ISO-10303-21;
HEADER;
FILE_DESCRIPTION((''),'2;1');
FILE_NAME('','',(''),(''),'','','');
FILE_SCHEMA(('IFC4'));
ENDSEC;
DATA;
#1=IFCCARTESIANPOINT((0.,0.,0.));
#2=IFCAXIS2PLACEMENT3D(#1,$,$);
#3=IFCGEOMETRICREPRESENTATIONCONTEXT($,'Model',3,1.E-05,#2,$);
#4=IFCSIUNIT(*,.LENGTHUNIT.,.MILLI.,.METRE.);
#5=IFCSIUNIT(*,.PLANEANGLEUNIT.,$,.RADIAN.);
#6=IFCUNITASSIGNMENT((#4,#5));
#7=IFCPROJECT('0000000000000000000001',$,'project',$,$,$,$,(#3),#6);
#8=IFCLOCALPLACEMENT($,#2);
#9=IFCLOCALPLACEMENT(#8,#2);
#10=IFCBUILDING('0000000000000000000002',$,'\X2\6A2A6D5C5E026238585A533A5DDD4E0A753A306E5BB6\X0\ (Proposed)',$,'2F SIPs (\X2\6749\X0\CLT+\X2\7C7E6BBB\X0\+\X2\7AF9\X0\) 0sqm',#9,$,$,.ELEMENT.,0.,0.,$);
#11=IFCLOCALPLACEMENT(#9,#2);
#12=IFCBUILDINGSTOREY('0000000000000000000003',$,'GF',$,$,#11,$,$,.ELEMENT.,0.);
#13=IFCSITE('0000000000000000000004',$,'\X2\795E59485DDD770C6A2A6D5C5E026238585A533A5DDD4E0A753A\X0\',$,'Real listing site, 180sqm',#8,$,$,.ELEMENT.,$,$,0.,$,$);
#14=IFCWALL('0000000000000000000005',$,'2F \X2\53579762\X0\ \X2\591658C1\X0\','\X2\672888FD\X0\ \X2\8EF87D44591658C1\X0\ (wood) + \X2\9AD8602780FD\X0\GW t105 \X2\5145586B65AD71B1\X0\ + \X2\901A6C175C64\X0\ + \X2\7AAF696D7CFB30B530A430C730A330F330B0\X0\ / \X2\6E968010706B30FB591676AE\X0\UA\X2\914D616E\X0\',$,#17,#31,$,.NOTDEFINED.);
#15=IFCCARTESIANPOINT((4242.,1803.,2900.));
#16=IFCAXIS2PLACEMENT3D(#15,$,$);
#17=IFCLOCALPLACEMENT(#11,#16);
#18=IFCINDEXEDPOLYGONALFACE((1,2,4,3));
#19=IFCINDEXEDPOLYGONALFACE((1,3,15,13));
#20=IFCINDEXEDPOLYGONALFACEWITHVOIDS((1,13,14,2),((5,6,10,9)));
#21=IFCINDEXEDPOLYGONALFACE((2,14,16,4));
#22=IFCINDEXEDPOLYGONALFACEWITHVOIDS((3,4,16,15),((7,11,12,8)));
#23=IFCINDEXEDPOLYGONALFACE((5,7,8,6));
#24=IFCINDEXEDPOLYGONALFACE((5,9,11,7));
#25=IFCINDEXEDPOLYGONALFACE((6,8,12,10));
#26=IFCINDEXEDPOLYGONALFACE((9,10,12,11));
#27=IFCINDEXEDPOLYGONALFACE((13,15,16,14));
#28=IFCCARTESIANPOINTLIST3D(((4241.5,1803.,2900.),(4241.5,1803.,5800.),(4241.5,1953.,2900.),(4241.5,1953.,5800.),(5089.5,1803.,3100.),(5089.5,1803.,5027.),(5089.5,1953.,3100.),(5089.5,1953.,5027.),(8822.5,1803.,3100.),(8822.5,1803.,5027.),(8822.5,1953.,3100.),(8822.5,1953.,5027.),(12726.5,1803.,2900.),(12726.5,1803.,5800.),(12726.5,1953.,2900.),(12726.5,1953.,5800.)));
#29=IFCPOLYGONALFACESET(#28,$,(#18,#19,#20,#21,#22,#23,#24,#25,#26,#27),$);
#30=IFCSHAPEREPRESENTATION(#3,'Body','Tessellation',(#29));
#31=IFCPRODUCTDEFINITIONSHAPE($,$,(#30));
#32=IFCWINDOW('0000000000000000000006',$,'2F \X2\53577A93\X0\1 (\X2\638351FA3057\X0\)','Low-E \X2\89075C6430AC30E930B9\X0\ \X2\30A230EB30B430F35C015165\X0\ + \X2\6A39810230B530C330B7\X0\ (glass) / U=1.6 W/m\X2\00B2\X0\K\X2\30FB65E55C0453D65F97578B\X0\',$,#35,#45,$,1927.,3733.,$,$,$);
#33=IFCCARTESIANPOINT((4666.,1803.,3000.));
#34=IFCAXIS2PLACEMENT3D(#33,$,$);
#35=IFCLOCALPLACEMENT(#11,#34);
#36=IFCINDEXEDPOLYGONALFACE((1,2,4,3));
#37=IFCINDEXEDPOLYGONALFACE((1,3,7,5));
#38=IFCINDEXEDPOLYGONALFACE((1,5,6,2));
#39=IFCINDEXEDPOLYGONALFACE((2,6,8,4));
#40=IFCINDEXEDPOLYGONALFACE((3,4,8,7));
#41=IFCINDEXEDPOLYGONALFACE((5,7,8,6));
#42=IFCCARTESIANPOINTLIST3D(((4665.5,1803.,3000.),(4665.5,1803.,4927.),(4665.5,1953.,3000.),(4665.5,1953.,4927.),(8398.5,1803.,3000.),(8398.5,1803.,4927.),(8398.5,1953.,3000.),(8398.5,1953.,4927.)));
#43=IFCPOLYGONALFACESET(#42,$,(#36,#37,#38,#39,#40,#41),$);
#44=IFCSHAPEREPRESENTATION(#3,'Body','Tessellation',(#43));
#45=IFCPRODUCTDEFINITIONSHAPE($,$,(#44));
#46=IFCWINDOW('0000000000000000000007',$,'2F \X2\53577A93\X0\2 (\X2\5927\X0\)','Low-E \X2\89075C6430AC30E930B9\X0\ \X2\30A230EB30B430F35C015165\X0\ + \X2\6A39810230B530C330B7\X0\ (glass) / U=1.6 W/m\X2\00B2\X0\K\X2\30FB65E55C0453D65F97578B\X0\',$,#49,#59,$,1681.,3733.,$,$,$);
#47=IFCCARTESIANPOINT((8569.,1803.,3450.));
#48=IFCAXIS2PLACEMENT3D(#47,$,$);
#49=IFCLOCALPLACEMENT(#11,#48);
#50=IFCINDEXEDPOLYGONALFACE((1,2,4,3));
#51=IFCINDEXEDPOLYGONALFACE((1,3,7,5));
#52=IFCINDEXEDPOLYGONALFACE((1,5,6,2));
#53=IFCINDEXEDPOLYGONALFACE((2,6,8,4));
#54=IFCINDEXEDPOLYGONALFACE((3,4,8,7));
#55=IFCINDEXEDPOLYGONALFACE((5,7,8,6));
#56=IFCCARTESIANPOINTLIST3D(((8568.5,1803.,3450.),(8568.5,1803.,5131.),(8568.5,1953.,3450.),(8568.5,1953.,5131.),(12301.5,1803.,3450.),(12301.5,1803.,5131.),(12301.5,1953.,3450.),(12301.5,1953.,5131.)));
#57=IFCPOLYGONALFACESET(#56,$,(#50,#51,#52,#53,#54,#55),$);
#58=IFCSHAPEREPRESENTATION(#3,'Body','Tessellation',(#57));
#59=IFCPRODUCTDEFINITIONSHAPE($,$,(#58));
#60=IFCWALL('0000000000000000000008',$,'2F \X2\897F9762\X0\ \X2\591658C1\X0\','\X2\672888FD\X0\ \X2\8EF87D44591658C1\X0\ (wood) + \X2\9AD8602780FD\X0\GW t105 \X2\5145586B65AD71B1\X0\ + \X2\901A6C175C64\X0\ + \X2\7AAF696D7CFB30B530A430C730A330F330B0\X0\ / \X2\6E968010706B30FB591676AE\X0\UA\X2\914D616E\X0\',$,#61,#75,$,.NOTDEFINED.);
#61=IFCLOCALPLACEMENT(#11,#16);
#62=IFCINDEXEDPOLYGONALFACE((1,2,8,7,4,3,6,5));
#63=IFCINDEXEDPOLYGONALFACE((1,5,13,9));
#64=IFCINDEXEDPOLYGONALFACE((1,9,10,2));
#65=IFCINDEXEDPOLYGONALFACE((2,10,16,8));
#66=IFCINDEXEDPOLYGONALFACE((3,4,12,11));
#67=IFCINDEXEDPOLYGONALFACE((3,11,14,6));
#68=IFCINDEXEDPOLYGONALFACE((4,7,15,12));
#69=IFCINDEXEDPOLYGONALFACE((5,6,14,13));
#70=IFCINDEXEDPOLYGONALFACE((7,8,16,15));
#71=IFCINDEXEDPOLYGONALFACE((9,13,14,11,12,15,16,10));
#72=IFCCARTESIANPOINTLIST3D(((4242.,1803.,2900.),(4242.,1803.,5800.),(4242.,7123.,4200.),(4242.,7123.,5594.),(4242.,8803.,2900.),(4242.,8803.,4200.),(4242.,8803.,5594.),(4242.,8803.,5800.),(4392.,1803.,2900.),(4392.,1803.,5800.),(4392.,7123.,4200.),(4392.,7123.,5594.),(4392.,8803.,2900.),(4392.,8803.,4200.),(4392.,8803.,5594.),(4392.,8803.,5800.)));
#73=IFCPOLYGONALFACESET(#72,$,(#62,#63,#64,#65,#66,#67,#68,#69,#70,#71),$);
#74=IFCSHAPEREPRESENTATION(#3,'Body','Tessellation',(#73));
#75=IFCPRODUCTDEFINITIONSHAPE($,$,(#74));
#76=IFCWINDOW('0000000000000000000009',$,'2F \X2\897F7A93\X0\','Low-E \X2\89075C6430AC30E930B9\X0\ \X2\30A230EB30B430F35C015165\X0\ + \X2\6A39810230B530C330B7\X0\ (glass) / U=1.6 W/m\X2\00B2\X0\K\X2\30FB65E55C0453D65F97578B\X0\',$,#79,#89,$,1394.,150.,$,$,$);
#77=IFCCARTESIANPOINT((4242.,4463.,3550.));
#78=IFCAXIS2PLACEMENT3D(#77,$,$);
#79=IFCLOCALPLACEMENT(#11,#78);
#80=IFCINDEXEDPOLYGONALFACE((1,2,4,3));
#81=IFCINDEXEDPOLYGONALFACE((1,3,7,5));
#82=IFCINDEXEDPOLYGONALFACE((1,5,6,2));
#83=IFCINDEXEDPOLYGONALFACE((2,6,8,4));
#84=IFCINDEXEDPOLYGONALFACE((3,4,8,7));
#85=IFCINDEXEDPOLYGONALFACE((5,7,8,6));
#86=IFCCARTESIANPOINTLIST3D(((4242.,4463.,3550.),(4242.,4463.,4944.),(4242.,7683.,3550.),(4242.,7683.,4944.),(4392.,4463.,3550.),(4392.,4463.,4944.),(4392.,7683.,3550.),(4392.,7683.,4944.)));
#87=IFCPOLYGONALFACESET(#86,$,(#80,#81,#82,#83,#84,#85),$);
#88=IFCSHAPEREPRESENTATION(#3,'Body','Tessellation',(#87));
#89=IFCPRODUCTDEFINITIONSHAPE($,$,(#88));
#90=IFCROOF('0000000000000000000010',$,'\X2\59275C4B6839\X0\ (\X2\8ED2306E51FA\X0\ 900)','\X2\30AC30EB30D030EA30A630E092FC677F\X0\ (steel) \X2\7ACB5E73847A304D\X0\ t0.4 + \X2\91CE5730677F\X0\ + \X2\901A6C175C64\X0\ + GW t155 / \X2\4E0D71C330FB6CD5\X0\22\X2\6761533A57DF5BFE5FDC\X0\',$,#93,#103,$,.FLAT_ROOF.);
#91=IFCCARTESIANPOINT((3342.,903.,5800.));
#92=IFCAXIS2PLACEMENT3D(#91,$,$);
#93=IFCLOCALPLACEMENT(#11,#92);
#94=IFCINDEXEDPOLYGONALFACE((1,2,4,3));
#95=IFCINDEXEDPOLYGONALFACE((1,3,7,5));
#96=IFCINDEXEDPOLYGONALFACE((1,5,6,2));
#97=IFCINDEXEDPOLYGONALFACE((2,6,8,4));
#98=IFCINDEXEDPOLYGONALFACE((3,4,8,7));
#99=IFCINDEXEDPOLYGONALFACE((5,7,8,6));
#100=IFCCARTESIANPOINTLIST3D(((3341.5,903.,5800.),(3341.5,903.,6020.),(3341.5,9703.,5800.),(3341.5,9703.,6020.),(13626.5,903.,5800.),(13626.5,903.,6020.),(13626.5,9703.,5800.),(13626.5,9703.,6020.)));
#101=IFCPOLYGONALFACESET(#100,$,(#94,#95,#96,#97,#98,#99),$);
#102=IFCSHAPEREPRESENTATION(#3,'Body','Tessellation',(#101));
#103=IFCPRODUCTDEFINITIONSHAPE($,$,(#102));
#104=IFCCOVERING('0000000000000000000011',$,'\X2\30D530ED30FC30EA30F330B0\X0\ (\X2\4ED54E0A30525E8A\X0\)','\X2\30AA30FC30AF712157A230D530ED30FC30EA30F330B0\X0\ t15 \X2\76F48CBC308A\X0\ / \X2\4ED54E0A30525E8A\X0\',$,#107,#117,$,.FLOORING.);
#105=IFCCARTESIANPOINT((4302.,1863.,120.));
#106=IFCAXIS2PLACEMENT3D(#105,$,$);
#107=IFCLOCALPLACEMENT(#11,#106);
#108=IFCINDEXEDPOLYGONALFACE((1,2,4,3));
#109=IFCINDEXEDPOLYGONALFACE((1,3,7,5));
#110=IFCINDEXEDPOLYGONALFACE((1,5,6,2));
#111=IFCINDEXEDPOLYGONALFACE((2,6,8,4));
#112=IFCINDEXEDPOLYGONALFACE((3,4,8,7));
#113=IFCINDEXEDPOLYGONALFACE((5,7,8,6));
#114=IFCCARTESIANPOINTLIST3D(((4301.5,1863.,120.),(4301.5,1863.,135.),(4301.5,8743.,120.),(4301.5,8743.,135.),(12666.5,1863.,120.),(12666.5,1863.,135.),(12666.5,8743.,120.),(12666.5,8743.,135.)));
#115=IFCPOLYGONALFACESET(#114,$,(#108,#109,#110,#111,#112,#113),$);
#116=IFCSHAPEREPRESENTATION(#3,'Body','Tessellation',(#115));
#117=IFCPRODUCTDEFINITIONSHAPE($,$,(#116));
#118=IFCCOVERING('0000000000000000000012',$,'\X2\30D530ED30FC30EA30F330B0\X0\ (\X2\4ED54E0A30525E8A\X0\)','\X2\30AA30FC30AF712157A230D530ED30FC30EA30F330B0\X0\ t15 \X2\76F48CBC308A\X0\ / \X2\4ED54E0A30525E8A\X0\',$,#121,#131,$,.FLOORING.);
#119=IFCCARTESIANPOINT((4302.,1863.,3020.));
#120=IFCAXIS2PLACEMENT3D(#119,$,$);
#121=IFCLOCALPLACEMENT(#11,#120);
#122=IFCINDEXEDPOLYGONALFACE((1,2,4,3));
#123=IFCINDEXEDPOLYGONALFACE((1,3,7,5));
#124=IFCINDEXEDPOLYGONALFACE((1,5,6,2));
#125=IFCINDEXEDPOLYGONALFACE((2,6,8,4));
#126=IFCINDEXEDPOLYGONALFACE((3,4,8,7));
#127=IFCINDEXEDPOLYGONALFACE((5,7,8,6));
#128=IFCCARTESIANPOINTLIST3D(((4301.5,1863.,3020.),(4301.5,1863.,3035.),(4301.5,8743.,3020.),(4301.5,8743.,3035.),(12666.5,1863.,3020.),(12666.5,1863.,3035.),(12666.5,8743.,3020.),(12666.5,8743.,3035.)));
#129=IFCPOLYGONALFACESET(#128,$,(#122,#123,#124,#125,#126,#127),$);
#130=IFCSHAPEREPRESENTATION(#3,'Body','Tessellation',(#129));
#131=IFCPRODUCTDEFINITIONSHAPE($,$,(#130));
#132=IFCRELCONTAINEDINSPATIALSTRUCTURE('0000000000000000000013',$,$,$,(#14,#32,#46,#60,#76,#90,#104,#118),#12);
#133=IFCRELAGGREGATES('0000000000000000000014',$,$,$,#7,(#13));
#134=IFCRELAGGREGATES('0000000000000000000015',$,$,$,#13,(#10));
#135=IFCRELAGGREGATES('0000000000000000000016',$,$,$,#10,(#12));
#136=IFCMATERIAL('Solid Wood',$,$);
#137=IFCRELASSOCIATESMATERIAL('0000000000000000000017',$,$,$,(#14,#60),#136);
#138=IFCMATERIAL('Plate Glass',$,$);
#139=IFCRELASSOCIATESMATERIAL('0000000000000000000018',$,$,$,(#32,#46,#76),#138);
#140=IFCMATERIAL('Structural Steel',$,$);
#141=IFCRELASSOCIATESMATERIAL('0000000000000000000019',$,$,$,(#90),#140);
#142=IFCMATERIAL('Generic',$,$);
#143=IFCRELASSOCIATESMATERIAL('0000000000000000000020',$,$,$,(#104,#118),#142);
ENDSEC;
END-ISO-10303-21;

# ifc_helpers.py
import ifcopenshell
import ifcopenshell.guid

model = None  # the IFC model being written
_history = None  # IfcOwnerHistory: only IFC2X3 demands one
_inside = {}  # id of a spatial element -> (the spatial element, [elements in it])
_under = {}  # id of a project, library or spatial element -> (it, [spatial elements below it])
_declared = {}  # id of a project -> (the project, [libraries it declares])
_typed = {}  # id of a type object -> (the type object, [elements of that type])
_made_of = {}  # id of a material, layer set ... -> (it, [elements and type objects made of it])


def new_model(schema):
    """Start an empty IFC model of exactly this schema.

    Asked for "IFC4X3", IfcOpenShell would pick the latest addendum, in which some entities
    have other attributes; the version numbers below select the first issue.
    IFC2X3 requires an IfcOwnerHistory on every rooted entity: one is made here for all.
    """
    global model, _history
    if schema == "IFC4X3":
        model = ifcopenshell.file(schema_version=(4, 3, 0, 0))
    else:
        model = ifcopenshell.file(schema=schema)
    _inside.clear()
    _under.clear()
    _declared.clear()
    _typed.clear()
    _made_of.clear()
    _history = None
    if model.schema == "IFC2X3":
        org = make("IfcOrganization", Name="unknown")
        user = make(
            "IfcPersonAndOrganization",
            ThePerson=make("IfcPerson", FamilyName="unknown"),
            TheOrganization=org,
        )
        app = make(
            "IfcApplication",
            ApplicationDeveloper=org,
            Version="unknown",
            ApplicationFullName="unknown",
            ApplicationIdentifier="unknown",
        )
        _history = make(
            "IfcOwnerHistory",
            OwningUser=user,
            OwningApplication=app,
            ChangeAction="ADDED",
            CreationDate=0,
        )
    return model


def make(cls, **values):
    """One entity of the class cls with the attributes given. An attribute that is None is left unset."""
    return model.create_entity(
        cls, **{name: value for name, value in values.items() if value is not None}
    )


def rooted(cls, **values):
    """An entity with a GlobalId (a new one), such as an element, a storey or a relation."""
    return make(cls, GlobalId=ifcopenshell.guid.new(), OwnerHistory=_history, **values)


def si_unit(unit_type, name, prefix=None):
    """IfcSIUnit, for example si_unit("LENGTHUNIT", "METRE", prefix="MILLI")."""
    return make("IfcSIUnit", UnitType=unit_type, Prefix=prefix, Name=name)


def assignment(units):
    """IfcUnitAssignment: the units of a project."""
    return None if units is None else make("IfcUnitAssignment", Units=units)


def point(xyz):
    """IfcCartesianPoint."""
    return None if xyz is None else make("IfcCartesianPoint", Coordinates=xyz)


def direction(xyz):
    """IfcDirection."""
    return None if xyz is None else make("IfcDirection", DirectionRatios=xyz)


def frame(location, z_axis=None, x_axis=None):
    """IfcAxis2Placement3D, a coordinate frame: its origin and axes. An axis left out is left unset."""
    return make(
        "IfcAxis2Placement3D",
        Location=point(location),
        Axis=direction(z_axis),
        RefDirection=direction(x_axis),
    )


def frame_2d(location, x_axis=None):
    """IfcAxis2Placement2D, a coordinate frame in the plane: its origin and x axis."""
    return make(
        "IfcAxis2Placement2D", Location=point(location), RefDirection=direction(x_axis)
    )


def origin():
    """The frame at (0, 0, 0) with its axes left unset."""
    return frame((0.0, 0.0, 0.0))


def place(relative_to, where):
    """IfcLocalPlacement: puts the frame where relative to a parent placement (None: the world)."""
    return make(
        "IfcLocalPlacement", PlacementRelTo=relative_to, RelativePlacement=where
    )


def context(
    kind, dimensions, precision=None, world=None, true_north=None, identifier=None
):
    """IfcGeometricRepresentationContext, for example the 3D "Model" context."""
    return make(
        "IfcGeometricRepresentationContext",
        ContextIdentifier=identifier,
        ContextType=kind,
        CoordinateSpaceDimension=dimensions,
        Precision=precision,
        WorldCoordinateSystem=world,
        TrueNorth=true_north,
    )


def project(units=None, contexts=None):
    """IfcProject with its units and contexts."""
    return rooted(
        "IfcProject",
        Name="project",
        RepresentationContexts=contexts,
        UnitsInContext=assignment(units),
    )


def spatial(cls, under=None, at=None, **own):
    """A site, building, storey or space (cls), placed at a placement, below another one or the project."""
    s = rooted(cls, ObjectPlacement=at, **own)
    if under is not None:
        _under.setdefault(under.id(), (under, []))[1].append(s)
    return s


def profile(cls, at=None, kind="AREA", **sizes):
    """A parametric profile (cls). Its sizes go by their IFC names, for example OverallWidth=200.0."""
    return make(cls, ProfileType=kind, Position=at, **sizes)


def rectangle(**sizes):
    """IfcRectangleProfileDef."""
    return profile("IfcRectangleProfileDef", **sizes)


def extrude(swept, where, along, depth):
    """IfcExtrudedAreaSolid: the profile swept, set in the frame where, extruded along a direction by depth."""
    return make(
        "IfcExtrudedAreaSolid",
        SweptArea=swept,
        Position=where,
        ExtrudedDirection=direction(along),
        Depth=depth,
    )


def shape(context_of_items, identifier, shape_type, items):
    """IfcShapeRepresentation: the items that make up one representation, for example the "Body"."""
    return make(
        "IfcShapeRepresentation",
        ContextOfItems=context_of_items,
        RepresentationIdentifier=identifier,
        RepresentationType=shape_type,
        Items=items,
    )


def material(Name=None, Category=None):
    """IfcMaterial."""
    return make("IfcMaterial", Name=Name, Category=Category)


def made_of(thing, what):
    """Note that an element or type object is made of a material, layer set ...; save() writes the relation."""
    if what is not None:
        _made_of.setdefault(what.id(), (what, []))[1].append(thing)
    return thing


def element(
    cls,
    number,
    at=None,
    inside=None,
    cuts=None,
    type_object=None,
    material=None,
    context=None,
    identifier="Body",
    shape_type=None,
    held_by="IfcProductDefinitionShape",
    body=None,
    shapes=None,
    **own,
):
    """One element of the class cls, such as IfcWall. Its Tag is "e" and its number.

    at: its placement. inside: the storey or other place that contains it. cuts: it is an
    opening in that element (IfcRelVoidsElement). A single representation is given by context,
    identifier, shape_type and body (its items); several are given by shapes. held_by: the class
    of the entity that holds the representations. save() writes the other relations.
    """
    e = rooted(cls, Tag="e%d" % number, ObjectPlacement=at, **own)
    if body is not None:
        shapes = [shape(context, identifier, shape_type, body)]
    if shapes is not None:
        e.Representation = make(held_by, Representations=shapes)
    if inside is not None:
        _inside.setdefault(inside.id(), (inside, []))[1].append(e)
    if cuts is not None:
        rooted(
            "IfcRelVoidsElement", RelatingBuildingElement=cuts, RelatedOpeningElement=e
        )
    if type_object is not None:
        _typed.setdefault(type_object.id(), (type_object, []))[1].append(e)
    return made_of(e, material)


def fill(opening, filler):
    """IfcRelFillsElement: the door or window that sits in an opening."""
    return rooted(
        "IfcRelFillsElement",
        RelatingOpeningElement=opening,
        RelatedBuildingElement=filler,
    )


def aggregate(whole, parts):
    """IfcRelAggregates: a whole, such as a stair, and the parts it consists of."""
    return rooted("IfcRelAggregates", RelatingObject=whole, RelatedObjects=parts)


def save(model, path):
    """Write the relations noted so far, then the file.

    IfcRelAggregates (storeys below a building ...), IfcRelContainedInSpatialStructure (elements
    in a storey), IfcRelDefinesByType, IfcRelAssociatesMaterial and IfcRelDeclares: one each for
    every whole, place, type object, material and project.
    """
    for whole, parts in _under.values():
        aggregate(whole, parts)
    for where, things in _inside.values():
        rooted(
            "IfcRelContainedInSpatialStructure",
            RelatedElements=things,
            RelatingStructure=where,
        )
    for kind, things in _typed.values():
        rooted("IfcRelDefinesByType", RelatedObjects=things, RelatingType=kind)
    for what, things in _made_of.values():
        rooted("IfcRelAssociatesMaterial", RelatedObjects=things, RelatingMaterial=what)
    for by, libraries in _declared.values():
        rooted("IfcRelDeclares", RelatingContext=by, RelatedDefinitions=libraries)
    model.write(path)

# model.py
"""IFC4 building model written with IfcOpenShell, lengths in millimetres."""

from ifc_helpers import new_model, si_unit, frame, frame_2d, origin, place, context, project, spatial, rectangle, extrude, material, element, fill, save


model = new_model("IFC4")

# Units and contexts
model_context = context("Model", 3, precision=1e-05, world=origin())
ifc_project = project(units=[si_unit("LENGTHUNIT", "METRE", prefix="MILLI"), si_unit("PLANEANGLEUNIT", "RADIAN")], contexts=[model_context])

# Site, building, storey
site_placement = place(None, origin())
site = spatial("IfcSite", under=ifc_project, at=site_placement, Name="神奈川県横浜市戸塚区川上町", ObjectType="Real listing site, 180sqm", CompositionType="ELEMENT", RefElevation=0.0)
building_placement = place(site_placement, origin())
building = spatial("IfcBuilding", under=site, at=building_placement, Name="横浜市戸塚区川上町の家 (Proposed)", ObjectType="2F SIPs (杉CLT+籾殻+竹) 0sqm", CompositionType="ELEMENT", ElevationOfRefHeight=0.0, ElevationOfTerrain=0.0)
storey_placement = place(building_placement, origin())
storey = spatial("IfcBuildingStorey", under=building, at=storey_placement, Name="GF", CompositionType="ELEMENT", Elevation=0.0)

# Shared definitions
ifc_material_1 = material(Name="Solid Wood")

# Shared definitions
ifc_material_2 = material(Name="Plate Glass")

# Wall, openings, windows
wall_1_placement = place(storey_placement, frame((4242.0, 1803.0, 2900.0)))
wall_1 = element("IfcWall", 1, at=wall_1_placement, inside=storey, material=ifc_material_1, Name="2F 南面 外壁", Description="木製 軸組外壁 (wood) + 高性能GW t105 充填断熱 + 通気層 + 窯業系サイディング / 準耐火・外皮UA配慮", PredefinedType="NOTDEFINED", context=model_context, shape_type="SweptSolid", body=[
    extrude(rectangle(XDim=8485.0, YDim=150.0, at=frame_2d((4242.0, 75.0))), frame((4242.0, 1803.0, 2900.0)), (0.0, 0.0, 1.0), 2900.0),
])
opening_1_placement = place(storey_placement, frame((4666.0, 1803.0, 3000.0)))
opening_1 = element("IfcOpeningElement", 2, at=opening_1_placement, cuts=wall_1, PredefinedType="NOTDEFINED", context=model_context, shape_type="SweptSolid", body=[
    extrude(rectangle(XDim=3733.0, YDim=150.0, at=frame_2d((1866.0, 75.0))), frame((4666.0, 1803.0, 3000.0)), (0.0, 0.0, 1.0), 1927.0),
])
opening_2_placement = place(storey_placement, frame((8569.0, 1803.0, 3450.0)))
opening_2 = element("IfcOpeningElement", 3, at=opening_2_placement, cuts=wall_1, PredefinedType="NOTDEFINED", context=model_context, shape_type="SweptSolid", body=[
    extrude(rectangle(XDim=3733.0, YDim=150.0, at=frame_2d((1866.0, 75.0))), frame((8569.0, 1803.0, 3450.0)), (0.0, 0.0, 1.0), 1681.0),
])
window_1_placement = place(storey_placement, frame((4666.0, 1803.0, 3000.0)))
window_1 = element("IfcWindow", 4, at=window_1_placement, inside=storey, material=ifc_material_2, Name="2F 南窓1 (掃出し)", Description="Low-E 複層ガラス アルゴン封入 + 樹脂サッシ (glass) / U=1.6 W/m²K・日射取得型", OverallHeight=1927.0, OverallWidth=3733.0, context=model_context, shape_type="SweptSolid", body=[
    extrude(rectangle(XDim=3733.0, YDim=150.0, at=frame_2d((1866.0, 75.0))), frame((4666.0, 1803.0, 3000.0)), (0.0, 0.0, 1.0), 1927.0),
])
fill(opening_1, window_1)
window_2_placement = place(storey_placement, frame((8569.0, 1803.0, 3450.0)))
window_2 = element("IfcWindow", 5, at=window_2_placement, inside=storey, material=ifc_material_2, Name="2F 南窓2 (大)", Description="Low-E 複層ガラス アルゴン封入 + 樹脂サッシ (glass) / U=1.6 W/m²K・日射取得型", OverallHeight=1681.0, OverallWidth=3733.0, context=model_context, shape_type="SweptSolid", body=[
    extrude(rectangle(XDim=3733.0, YDim=150.0, at=frame_2d((1866.0, 75.0))), frame((8569.0, 1803.0, 3450.0)), (0.0, 0.0, 1.0), 1681.0),
])
fill(opening_2, window_2)

# Wall, opening, window
wall_2_placement = place(storey_placement, frame((4242.0, 1803.0, 2900.0)))
wall_2 = element("IfcWall", 6, at=wall_2_placement, inside=storey, material=ifc_material_1, Name="2F 西面 外壁", Description="木製 軸組外壁 (wood) + 高性能GW t105 充填断熱 + 通気層 + 窯業系サイディング / 準耐火・外皮UA配慮", PredefinedType="NOTDEFINED", context=model_context, shape_type="SweptSolid", body=[
    extrude(rectangle(XDim=150.0, YDim=7000.0, at=frame_2d((75.0, 3500.0))), frame((4242.0, 1803.0, 2900.0)), (0.0, 0.0, 1.0), 2900.0),
])
opening_3_placement = place(storey_placement, frame((4242.0, 4463.0, 3550.0)))
opening_3 = element("IfcOpeningElement", 7, at=opening_3_placement, cuts=wall_2, PredefinedType="NOTDEFINED", context=model_context, shape_type="SweptSolid", body=[
    extrude(rectangle(XDim=150.0, YDim=3220.0, at=frame_2d((75.0, 1610.0))), frame((4242.0, 4463.0, 3550.0)), (0.0, 0.0, 1.0), 1394.0),
])
window_3_placement = place(storey_placement, frame((4242.0, 4463.0, 3550.0)))
window_3 = element("IfcWindow", 8, at=window_3_placement, inside=storey, material=ifc_material_2, Name="2F 西窓", Description="Low-E 複層ガラス アルゴン封入 + 樹脂サッシ (glass) / U=1.6 W/m²K・日射取得型", OverallHeight=1394.0, OverallWidth=150.0, context=model_context, shape_type="SweptSolid", body=[
    extrude(rectangle(XDim=150.0, YDim=3220.0, at=frame_2d((75.0, 1610.0))), frame((4242.0, 4463.0, 3550.0)), (0.0, 0.0, 1.0), 1394.0),
])
fill(opening_3, window_3)

# Roof
ifc_material_3 = material(Name="Structural Steel")
roof_placement = place(storey_placement, frame((3342.0, 903.0, 5800.0)))
element("IfcRoof", 9, at=roof_placement, inside=storey, material=ifc_material_3, Name="大屋根 (軒の出 900)", Description="ガルバリウム鋼板 (steel) 立平葺き t0.4 + 野地板 + 通気層 + GW t155 / 不燃・法22条区域対応", PredefinedType="FLAT_ROOF", context=model_context, shape_type="SweptSolid", body=[
    extrude(rectangle(XDim=10285.0, YDim=8800.0, at=frame_2d((5142.0, 4400.0))), frame((3342.0, 903.0, 5800.0)), (0.0, 0.0, 1.0), 220.0),
])

# Coverings
ifc_material_4 = material(Name="Generic")
covering_1_placement = place(storey_placement, frame((4302.0, 1863.0, 120.0)))
element("IfcCovering", 10, at=covering_1_placement, inside=storey, material=ifc_material_4, Name="フローリング (仕上げ床)", Description="オーク無垢フローリング t15 直貼り / 仕上げ床", PredefinedType="FLOORING", context=model_context, shape_type="SweptSolid", body=[
    extrude(rectangle(XDim=8365.0, YDim=6880.0, at=frame_2d((4182.0, 3440.0))), frame((4302.0, 1863.0, 120.0)), (0.0, 0.0, 1.0), 15.0),
])
covering_2_placement = place(storey_placement, frame((4302.0, 1863.0, 3020.0)))
element("IfcCovering", 11, at=covering_2_placement, inside=storey, material=ifc_material_4, Name="フローリング (仕上げ床)", Description="オーク無垢フローリング t15 直貼り / 仕上げ床", PredefinedType="FLOORING", context=model_context, shape_type="SweptSolid", body=[
    extrude(rectangle(XDim=8365.0, YDim=6880.0, at=frame_2d((4182.0, 3440.0))), frame((4302.0, 1863.0, 3020.0)), (0.0, 0.0, 1.0), 15.0),
])

save(model, "model.ifc")
